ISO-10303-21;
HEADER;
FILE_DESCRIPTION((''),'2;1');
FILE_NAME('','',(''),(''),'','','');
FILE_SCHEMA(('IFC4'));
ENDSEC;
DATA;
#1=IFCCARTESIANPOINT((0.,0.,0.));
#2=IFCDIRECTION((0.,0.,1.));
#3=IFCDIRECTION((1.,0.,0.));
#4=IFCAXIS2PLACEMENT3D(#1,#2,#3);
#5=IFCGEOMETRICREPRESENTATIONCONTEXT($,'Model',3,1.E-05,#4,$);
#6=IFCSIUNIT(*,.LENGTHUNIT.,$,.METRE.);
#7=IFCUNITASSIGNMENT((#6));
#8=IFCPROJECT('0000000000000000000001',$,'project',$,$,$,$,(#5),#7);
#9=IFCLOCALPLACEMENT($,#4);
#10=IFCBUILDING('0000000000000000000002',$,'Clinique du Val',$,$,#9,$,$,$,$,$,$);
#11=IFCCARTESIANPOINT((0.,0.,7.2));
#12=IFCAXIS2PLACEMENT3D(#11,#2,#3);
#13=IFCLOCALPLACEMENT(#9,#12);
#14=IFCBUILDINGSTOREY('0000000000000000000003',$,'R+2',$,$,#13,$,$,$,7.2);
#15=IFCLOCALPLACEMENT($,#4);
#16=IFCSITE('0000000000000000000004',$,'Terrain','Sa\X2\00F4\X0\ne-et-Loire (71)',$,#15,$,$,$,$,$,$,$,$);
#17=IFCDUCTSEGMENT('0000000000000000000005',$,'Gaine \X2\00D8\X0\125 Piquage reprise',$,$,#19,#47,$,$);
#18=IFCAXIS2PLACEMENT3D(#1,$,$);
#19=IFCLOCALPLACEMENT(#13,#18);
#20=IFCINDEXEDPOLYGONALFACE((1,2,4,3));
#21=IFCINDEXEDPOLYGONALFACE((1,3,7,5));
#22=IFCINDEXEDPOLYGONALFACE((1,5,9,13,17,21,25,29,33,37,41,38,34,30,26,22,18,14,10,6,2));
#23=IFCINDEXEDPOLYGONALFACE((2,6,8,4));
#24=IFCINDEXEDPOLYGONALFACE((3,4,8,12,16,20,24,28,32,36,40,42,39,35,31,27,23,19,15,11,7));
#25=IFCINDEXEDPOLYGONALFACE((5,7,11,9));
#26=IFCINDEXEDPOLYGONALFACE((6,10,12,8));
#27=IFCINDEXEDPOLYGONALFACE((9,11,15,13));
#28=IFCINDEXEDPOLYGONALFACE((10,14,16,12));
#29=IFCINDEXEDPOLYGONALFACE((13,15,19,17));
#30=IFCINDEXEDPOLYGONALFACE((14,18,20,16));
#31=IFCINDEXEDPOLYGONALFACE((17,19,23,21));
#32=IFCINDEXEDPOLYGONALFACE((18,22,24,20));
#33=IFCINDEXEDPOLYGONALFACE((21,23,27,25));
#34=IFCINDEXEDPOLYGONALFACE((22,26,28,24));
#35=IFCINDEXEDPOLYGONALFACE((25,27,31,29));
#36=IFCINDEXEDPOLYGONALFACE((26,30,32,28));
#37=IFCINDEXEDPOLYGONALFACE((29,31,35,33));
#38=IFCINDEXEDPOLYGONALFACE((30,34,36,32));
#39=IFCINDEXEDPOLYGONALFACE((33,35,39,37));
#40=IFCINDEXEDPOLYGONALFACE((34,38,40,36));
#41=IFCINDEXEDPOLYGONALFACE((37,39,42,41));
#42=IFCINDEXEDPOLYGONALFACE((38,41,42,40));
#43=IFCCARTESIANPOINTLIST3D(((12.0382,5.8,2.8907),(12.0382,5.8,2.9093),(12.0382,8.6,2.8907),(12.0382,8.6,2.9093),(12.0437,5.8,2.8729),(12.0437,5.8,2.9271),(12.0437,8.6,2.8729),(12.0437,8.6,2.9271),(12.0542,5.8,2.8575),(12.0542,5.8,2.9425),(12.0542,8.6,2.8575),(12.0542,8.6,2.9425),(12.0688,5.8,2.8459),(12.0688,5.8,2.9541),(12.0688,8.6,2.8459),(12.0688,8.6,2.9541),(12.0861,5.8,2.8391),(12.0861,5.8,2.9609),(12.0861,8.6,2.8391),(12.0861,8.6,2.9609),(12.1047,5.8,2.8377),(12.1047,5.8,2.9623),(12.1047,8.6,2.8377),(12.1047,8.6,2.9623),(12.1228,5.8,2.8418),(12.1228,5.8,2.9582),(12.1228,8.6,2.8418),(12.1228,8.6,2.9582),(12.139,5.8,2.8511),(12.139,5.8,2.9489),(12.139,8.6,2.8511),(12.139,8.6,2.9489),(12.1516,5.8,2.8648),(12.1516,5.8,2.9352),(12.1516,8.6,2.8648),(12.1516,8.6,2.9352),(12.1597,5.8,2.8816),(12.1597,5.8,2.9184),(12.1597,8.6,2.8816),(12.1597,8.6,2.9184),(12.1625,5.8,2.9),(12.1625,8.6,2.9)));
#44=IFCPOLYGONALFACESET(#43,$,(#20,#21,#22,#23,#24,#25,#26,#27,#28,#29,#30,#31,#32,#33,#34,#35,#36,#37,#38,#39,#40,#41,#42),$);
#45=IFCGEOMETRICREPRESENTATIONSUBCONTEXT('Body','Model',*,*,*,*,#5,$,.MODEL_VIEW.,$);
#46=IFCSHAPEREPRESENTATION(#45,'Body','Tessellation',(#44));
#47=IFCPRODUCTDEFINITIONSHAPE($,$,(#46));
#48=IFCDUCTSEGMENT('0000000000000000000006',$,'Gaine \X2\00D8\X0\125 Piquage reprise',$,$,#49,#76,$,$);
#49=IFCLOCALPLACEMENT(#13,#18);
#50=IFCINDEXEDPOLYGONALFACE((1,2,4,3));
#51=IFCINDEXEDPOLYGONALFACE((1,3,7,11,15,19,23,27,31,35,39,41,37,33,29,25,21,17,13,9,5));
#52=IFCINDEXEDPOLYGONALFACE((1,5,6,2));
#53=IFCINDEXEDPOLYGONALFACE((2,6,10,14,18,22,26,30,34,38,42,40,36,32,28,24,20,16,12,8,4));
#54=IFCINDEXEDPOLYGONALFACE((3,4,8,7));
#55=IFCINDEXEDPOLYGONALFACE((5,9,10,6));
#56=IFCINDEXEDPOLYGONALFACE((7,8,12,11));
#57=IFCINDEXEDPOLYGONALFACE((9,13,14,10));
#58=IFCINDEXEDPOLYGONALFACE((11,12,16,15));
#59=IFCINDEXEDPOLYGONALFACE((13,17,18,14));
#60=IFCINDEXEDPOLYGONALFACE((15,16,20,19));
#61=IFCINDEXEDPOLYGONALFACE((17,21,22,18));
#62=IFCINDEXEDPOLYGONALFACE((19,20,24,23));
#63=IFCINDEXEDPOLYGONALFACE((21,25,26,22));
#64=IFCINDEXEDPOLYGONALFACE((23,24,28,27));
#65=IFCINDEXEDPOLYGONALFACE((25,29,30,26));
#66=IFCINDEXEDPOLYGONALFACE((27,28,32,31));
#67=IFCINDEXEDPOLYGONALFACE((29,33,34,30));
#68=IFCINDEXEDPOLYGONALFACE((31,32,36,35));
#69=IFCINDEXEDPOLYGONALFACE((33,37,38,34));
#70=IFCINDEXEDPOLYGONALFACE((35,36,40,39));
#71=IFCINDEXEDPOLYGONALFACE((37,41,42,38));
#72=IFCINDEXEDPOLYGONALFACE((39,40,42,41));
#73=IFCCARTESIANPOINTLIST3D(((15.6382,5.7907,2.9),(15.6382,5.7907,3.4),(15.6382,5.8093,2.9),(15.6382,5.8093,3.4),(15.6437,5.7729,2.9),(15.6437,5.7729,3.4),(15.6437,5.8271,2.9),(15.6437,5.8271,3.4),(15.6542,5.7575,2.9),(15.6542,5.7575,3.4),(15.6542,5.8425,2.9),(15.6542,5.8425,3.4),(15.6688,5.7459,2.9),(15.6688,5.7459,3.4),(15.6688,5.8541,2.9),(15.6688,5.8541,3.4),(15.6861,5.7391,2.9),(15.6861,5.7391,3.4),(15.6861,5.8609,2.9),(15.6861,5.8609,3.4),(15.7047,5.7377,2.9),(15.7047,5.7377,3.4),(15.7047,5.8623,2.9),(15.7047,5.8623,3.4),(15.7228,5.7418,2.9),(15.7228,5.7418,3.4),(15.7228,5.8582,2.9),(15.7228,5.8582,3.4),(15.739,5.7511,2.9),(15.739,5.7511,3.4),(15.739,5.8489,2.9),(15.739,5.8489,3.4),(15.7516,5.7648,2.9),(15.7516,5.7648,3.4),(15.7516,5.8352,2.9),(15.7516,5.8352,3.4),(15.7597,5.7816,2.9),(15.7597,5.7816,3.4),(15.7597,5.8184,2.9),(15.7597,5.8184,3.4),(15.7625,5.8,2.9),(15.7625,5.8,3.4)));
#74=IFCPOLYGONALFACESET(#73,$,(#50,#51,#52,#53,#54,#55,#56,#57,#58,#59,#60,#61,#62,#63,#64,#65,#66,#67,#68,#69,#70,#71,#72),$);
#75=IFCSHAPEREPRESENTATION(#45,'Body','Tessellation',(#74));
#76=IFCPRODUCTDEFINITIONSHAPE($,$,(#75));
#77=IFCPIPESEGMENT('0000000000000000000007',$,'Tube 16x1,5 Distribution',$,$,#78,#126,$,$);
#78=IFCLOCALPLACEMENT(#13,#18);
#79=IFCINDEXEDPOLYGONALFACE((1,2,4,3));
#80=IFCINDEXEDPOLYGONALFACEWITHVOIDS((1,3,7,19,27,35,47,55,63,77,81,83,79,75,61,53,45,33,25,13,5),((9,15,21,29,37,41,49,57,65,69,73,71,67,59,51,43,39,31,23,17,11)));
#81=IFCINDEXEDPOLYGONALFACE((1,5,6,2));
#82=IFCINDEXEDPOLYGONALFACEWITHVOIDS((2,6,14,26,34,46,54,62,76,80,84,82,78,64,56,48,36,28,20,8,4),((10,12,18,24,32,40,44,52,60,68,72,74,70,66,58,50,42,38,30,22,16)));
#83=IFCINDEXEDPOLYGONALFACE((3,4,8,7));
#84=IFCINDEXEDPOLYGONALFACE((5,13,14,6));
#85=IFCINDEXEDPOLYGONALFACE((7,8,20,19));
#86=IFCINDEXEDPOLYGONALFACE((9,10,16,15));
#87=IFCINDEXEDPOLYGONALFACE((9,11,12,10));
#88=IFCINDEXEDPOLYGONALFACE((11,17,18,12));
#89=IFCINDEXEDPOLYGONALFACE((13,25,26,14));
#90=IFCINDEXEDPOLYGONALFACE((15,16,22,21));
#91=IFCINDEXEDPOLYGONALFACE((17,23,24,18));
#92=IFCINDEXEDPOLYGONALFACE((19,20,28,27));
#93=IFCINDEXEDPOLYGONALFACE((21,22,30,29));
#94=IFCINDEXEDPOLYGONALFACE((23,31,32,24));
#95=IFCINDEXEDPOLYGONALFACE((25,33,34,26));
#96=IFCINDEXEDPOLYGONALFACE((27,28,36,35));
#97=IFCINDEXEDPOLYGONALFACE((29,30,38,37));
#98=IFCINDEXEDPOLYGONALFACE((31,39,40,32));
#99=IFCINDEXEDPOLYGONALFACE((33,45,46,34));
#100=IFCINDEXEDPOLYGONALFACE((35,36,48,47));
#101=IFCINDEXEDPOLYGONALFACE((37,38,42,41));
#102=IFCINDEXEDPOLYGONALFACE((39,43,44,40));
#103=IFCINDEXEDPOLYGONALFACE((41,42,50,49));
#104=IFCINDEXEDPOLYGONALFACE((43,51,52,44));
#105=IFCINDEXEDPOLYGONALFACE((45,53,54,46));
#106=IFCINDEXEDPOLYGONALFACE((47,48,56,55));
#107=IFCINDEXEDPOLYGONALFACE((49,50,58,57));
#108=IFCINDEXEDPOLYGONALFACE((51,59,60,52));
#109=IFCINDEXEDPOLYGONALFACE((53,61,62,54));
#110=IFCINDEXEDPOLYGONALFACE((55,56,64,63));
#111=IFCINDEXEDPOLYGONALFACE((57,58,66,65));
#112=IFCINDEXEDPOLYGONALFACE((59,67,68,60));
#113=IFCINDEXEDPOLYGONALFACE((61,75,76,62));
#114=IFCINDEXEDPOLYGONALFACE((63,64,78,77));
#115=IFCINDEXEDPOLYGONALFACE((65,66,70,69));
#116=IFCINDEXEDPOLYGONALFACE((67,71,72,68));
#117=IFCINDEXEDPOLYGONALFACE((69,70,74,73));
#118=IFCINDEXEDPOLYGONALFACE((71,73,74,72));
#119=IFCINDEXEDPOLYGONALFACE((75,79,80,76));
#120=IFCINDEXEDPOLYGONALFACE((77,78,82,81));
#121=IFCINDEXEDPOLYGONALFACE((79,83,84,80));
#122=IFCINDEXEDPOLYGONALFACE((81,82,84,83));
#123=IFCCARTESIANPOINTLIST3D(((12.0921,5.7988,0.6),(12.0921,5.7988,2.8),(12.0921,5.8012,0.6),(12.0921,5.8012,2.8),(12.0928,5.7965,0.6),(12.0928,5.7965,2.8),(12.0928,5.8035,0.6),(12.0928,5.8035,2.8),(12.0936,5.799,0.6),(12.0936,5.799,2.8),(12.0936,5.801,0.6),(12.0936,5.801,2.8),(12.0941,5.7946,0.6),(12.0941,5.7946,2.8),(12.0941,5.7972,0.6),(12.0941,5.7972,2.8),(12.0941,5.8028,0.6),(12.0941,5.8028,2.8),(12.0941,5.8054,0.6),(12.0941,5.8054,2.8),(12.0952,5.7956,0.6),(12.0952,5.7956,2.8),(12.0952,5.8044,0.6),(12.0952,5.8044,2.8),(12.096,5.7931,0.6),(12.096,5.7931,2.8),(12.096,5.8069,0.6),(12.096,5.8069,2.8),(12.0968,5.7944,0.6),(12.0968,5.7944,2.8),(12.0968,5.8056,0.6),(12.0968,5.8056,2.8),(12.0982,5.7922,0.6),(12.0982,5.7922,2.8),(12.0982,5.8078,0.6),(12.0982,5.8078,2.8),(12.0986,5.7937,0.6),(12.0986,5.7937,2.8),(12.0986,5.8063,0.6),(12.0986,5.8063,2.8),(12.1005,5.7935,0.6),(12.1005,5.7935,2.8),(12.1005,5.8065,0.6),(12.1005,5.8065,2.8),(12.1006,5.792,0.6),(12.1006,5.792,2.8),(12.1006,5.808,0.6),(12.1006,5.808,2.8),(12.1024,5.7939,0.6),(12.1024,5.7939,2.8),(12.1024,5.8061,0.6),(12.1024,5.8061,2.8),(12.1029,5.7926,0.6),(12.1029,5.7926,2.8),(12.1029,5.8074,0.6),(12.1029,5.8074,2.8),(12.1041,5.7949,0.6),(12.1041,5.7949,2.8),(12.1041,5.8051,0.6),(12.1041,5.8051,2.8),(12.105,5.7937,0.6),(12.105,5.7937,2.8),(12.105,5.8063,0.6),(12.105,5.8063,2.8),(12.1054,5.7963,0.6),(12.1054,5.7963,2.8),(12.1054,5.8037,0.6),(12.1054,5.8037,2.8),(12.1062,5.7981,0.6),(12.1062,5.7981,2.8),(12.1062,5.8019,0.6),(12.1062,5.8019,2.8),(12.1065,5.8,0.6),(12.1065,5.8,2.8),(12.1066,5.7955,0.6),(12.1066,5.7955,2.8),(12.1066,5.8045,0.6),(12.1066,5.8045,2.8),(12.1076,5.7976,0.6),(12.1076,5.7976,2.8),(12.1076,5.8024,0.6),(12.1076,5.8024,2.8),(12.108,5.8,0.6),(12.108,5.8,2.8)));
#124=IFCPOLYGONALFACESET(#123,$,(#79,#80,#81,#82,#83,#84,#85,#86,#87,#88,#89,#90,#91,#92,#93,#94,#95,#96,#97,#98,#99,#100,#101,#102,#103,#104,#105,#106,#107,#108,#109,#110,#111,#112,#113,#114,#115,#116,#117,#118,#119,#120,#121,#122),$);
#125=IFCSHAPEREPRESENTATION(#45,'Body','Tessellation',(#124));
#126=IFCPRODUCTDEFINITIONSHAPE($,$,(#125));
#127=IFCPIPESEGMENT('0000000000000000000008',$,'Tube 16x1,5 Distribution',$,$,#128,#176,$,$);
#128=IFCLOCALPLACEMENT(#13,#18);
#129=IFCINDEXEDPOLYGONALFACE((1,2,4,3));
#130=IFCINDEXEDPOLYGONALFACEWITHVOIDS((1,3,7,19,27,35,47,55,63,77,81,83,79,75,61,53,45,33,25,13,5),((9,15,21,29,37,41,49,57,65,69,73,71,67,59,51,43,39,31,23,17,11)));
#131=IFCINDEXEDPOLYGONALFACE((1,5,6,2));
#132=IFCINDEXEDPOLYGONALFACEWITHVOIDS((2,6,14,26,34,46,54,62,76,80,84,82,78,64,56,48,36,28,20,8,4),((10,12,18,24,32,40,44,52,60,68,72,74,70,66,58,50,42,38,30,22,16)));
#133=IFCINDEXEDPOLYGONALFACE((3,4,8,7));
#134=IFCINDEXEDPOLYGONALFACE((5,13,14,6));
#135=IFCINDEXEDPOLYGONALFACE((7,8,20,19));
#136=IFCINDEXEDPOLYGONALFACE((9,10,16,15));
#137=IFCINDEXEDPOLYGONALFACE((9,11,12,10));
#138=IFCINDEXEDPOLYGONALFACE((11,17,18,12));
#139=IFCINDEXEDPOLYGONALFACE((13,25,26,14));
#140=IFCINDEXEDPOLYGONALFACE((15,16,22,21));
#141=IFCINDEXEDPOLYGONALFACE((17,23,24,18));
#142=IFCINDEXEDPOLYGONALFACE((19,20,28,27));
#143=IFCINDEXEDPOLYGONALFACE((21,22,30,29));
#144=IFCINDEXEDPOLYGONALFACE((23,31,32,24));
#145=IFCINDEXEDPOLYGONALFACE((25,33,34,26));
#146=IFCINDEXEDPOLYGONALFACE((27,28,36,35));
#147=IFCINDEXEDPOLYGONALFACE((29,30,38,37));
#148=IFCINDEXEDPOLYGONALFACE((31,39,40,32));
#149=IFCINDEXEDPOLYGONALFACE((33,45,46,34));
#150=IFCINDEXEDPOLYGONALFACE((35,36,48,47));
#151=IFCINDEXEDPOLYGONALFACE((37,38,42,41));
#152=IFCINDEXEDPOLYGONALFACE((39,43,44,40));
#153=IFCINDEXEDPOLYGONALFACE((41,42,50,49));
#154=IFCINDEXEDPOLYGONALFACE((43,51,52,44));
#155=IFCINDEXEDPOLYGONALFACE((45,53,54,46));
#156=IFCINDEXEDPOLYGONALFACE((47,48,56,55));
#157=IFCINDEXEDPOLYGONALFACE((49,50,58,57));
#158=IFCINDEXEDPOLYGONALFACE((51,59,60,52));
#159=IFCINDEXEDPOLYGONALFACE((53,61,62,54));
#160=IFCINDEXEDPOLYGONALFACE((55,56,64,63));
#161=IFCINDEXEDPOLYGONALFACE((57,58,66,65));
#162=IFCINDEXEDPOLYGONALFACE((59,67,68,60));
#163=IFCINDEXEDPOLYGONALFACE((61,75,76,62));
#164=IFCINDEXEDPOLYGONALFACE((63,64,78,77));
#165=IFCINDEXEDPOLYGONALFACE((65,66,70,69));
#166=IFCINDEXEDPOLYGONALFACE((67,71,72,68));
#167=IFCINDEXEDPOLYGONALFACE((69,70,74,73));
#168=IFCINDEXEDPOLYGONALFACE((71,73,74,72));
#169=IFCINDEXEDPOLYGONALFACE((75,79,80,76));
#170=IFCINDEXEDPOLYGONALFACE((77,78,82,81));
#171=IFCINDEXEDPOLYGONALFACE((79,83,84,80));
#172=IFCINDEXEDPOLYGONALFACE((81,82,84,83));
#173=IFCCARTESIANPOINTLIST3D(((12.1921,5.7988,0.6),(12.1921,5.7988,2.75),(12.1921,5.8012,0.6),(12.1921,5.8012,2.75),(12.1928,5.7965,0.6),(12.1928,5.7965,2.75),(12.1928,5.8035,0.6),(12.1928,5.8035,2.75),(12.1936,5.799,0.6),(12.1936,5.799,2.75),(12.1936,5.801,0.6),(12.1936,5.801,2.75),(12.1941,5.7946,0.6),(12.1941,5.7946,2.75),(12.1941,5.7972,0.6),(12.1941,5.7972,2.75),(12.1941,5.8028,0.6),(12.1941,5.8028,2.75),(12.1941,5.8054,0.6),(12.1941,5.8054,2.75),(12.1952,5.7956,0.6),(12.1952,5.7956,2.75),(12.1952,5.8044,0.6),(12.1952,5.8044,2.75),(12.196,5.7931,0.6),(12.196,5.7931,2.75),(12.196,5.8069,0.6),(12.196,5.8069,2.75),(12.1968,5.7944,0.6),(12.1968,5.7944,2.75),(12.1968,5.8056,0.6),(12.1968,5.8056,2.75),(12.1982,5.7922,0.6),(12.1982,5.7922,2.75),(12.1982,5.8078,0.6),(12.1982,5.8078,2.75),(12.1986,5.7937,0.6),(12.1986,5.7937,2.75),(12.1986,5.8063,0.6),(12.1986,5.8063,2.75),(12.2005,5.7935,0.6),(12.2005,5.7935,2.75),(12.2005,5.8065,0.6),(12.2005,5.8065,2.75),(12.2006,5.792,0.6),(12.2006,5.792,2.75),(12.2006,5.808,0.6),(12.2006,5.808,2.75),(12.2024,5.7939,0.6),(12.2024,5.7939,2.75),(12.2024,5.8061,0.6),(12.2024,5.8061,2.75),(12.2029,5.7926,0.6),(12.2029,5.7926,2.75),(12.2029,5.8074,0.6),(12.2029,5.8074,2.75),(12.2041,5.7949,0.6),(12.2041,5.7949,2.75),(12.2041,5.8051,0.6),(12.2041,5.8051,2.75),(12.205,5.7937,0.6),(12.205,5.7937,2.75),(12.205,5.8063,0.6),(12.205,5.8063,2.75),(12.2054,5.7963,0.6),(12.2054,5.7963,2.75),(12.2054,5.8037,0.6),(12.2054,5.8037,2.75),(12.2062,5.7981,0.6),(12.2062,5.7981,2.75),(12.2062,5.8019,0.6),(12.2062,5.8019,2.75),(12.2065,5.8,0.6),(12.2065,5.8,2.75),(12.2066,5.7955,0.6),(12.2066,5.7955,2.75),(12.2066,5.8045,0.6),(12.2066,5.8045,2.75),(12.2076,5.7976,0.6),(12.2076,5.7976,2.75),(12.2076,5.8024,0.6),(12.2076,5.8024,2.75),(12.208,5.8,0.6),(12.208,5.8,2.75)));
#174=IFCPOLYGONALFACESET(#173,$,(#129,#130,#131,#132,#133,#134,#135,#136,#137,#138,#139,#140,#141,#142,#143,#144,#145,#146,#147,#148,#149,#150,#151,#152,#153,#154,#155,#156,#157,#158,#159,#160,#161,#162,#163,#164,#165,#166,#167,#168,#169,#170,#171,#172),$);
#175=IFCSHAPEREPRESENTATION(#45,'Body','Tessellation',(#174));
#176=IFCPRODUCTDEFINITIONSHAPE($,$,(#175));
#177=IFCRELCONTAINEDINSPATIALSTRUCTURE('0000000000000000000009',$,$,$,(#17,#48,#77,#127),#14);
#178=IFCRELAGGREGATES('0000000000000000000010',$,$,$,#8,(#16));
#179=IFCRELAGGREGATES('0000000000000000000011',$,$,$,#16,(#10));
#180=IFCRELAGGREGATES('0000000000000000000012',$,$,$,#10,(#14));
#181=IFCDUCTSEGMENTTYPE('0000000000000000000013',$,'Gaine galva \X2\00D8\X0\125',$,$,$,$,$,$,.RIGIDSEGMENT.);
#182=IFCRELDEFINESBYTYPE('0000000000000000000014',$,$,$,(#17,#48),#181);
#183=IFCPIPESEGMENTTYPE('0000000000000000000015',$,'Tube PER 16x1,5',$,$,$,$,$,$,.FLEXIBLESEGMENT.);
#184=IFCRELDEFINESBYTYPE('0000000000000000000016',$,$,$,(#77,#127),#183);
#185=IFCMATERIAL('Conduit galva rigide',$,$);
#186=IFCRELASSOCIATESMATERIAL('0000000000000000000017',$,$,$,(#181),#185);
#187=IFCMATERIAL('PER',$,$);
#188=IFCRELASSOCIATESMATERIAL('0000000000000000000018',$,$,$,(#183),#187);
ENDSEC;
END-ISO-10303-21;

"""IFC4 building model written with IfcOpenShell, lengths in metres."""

from ifc_helpers import new_model, si_unit, frame, origin_with_axes, place, context, subcontext, project, spatial, circle, hollow_circle, extrude, material, type_object, element, save


model = new_model("IFC4")

# Units and contexts
model_context = context("Model", 3, precision=1e-05, world=origin_with_axes())
body_context = subcontext(model_context, "Body", "Model", "MODEL_VIEW")
ifc_project = project(units=[si_unit("LENGTHUNIT", "METRE")], contexts=[model_context])

# Site, building, storey
site_placement = place(None, origin_with_axes())
site = spatial("IfcSite", under=ifc_project, at=site_placement, Name="Terrain", Description="Saône-et-Loire (71)")
building_placement = place(None, origin_with_axes())
building = spatial("IfcBuilding", under=site, at=building_placement, Name="Clinique du Val")
storey_placement = place(building_placement, frame((0.0, 0.0, 7.2), z_axis=(0.0, 0.0, 1.0), x_axis=(1.0, 0.0, 0.0)))
storey = spatial("IfcBuildingStorey", under=building, at=storey_placement, Name="R+2", Elevation=7.2)

# Duct segments
ifc_material_1 = material(Name="Conduit galva rigide")
duct_segment_type = type_object("IfcDuctSegmentType", Name="Gaine galva Ø125", PredefinedType="RIGIDSEGMENT", material=ifc_material_1)
duct_segment_1_placement = place(storey_placement, frame((12.1, 5.8, 2.9), z_axis=(0.0, 1.0, 0.0), x_axis=(1.0, 0.0, 0.0)))
element("IfcDuctSegment", 1, at=duct_segment_1_placement, inside=storey, type_object=duct_segment_type, Name="Gaine Ø125 Piquage reprise", context=body_context, shape_type="SweptSolid", body=[
    extrude(circle(Radius=0.0625), origin_with_axes(), (0.0, 0.0, 1.0), 2.8),
])
duct_segment_2_placement = place(storey_placement, frame((15.7, 5.8, 3.4), z_axis=(0.0, 0.0, -1.0), x_axis=(1.0, 0.0, 0.0)))
element("IfcDuctSegment", 2, at=duct_segment_2_placement, inside=storey, type_object=duct_segment_type, Name="Gaine Ø125 Piquage reprise", context=body_context, shape_type="SweptSolid", body=[
    extrude(circle(Radius=0.0625), origin_with_axes(), (0.0, 0.0, 1.0), 0.5),
])

# Pipe segments
ifc_material_2 = material(Name="PER")
pipe_segment_type_1 = type_object("IfcPipeSegmentType", Name="Tube PER 16x1,5", PredefinedType="FLEXIBLESEGMENT", material=ifc_material_2)
pipe_segment_1_placement = place(storey_placement, frame((12.1, 5.8, 2.8), z_axis=(0.0, 0.0, -1.0), x_axis=(1.0, 0.0, 0.0)))
element("IfcPipeSegment", 3, at=pipe_segment_1_placement, inside=storey, type_object=pipe_segment_type_1, Name="Tube 16x1,5 Distribution", context=body_context, shape_type="SweptSolid", body=[
    extrude(hollow_circle(Radius=0.008, WallThickness=0.0015), origin_with_axes(), (0.0, 0.0, 1.0), 2.2),
])
pipe_segment_2_placement = place(storey_placement, frame((12.2, 5.8, 2.75), z_axis=(0.0, 0.0, -1.0), x_axis=(1.0, 0.0, 0.0)))
element("IfcPipeSegment", 4, at=pipe_segment_2_placement, inside=storey, type_object=pipe_segment_type_1, Name="Tube 16x1,5 Distribution", context=body_context, shape_type="SweptSolid", body=[
    extrude(hollow_circle(Radius=0.008, WallThickness=0.0015), origin_with_axes(), (0.0, 0.0, 1.0), 2.15),
])

save(model, "model.ifc")
